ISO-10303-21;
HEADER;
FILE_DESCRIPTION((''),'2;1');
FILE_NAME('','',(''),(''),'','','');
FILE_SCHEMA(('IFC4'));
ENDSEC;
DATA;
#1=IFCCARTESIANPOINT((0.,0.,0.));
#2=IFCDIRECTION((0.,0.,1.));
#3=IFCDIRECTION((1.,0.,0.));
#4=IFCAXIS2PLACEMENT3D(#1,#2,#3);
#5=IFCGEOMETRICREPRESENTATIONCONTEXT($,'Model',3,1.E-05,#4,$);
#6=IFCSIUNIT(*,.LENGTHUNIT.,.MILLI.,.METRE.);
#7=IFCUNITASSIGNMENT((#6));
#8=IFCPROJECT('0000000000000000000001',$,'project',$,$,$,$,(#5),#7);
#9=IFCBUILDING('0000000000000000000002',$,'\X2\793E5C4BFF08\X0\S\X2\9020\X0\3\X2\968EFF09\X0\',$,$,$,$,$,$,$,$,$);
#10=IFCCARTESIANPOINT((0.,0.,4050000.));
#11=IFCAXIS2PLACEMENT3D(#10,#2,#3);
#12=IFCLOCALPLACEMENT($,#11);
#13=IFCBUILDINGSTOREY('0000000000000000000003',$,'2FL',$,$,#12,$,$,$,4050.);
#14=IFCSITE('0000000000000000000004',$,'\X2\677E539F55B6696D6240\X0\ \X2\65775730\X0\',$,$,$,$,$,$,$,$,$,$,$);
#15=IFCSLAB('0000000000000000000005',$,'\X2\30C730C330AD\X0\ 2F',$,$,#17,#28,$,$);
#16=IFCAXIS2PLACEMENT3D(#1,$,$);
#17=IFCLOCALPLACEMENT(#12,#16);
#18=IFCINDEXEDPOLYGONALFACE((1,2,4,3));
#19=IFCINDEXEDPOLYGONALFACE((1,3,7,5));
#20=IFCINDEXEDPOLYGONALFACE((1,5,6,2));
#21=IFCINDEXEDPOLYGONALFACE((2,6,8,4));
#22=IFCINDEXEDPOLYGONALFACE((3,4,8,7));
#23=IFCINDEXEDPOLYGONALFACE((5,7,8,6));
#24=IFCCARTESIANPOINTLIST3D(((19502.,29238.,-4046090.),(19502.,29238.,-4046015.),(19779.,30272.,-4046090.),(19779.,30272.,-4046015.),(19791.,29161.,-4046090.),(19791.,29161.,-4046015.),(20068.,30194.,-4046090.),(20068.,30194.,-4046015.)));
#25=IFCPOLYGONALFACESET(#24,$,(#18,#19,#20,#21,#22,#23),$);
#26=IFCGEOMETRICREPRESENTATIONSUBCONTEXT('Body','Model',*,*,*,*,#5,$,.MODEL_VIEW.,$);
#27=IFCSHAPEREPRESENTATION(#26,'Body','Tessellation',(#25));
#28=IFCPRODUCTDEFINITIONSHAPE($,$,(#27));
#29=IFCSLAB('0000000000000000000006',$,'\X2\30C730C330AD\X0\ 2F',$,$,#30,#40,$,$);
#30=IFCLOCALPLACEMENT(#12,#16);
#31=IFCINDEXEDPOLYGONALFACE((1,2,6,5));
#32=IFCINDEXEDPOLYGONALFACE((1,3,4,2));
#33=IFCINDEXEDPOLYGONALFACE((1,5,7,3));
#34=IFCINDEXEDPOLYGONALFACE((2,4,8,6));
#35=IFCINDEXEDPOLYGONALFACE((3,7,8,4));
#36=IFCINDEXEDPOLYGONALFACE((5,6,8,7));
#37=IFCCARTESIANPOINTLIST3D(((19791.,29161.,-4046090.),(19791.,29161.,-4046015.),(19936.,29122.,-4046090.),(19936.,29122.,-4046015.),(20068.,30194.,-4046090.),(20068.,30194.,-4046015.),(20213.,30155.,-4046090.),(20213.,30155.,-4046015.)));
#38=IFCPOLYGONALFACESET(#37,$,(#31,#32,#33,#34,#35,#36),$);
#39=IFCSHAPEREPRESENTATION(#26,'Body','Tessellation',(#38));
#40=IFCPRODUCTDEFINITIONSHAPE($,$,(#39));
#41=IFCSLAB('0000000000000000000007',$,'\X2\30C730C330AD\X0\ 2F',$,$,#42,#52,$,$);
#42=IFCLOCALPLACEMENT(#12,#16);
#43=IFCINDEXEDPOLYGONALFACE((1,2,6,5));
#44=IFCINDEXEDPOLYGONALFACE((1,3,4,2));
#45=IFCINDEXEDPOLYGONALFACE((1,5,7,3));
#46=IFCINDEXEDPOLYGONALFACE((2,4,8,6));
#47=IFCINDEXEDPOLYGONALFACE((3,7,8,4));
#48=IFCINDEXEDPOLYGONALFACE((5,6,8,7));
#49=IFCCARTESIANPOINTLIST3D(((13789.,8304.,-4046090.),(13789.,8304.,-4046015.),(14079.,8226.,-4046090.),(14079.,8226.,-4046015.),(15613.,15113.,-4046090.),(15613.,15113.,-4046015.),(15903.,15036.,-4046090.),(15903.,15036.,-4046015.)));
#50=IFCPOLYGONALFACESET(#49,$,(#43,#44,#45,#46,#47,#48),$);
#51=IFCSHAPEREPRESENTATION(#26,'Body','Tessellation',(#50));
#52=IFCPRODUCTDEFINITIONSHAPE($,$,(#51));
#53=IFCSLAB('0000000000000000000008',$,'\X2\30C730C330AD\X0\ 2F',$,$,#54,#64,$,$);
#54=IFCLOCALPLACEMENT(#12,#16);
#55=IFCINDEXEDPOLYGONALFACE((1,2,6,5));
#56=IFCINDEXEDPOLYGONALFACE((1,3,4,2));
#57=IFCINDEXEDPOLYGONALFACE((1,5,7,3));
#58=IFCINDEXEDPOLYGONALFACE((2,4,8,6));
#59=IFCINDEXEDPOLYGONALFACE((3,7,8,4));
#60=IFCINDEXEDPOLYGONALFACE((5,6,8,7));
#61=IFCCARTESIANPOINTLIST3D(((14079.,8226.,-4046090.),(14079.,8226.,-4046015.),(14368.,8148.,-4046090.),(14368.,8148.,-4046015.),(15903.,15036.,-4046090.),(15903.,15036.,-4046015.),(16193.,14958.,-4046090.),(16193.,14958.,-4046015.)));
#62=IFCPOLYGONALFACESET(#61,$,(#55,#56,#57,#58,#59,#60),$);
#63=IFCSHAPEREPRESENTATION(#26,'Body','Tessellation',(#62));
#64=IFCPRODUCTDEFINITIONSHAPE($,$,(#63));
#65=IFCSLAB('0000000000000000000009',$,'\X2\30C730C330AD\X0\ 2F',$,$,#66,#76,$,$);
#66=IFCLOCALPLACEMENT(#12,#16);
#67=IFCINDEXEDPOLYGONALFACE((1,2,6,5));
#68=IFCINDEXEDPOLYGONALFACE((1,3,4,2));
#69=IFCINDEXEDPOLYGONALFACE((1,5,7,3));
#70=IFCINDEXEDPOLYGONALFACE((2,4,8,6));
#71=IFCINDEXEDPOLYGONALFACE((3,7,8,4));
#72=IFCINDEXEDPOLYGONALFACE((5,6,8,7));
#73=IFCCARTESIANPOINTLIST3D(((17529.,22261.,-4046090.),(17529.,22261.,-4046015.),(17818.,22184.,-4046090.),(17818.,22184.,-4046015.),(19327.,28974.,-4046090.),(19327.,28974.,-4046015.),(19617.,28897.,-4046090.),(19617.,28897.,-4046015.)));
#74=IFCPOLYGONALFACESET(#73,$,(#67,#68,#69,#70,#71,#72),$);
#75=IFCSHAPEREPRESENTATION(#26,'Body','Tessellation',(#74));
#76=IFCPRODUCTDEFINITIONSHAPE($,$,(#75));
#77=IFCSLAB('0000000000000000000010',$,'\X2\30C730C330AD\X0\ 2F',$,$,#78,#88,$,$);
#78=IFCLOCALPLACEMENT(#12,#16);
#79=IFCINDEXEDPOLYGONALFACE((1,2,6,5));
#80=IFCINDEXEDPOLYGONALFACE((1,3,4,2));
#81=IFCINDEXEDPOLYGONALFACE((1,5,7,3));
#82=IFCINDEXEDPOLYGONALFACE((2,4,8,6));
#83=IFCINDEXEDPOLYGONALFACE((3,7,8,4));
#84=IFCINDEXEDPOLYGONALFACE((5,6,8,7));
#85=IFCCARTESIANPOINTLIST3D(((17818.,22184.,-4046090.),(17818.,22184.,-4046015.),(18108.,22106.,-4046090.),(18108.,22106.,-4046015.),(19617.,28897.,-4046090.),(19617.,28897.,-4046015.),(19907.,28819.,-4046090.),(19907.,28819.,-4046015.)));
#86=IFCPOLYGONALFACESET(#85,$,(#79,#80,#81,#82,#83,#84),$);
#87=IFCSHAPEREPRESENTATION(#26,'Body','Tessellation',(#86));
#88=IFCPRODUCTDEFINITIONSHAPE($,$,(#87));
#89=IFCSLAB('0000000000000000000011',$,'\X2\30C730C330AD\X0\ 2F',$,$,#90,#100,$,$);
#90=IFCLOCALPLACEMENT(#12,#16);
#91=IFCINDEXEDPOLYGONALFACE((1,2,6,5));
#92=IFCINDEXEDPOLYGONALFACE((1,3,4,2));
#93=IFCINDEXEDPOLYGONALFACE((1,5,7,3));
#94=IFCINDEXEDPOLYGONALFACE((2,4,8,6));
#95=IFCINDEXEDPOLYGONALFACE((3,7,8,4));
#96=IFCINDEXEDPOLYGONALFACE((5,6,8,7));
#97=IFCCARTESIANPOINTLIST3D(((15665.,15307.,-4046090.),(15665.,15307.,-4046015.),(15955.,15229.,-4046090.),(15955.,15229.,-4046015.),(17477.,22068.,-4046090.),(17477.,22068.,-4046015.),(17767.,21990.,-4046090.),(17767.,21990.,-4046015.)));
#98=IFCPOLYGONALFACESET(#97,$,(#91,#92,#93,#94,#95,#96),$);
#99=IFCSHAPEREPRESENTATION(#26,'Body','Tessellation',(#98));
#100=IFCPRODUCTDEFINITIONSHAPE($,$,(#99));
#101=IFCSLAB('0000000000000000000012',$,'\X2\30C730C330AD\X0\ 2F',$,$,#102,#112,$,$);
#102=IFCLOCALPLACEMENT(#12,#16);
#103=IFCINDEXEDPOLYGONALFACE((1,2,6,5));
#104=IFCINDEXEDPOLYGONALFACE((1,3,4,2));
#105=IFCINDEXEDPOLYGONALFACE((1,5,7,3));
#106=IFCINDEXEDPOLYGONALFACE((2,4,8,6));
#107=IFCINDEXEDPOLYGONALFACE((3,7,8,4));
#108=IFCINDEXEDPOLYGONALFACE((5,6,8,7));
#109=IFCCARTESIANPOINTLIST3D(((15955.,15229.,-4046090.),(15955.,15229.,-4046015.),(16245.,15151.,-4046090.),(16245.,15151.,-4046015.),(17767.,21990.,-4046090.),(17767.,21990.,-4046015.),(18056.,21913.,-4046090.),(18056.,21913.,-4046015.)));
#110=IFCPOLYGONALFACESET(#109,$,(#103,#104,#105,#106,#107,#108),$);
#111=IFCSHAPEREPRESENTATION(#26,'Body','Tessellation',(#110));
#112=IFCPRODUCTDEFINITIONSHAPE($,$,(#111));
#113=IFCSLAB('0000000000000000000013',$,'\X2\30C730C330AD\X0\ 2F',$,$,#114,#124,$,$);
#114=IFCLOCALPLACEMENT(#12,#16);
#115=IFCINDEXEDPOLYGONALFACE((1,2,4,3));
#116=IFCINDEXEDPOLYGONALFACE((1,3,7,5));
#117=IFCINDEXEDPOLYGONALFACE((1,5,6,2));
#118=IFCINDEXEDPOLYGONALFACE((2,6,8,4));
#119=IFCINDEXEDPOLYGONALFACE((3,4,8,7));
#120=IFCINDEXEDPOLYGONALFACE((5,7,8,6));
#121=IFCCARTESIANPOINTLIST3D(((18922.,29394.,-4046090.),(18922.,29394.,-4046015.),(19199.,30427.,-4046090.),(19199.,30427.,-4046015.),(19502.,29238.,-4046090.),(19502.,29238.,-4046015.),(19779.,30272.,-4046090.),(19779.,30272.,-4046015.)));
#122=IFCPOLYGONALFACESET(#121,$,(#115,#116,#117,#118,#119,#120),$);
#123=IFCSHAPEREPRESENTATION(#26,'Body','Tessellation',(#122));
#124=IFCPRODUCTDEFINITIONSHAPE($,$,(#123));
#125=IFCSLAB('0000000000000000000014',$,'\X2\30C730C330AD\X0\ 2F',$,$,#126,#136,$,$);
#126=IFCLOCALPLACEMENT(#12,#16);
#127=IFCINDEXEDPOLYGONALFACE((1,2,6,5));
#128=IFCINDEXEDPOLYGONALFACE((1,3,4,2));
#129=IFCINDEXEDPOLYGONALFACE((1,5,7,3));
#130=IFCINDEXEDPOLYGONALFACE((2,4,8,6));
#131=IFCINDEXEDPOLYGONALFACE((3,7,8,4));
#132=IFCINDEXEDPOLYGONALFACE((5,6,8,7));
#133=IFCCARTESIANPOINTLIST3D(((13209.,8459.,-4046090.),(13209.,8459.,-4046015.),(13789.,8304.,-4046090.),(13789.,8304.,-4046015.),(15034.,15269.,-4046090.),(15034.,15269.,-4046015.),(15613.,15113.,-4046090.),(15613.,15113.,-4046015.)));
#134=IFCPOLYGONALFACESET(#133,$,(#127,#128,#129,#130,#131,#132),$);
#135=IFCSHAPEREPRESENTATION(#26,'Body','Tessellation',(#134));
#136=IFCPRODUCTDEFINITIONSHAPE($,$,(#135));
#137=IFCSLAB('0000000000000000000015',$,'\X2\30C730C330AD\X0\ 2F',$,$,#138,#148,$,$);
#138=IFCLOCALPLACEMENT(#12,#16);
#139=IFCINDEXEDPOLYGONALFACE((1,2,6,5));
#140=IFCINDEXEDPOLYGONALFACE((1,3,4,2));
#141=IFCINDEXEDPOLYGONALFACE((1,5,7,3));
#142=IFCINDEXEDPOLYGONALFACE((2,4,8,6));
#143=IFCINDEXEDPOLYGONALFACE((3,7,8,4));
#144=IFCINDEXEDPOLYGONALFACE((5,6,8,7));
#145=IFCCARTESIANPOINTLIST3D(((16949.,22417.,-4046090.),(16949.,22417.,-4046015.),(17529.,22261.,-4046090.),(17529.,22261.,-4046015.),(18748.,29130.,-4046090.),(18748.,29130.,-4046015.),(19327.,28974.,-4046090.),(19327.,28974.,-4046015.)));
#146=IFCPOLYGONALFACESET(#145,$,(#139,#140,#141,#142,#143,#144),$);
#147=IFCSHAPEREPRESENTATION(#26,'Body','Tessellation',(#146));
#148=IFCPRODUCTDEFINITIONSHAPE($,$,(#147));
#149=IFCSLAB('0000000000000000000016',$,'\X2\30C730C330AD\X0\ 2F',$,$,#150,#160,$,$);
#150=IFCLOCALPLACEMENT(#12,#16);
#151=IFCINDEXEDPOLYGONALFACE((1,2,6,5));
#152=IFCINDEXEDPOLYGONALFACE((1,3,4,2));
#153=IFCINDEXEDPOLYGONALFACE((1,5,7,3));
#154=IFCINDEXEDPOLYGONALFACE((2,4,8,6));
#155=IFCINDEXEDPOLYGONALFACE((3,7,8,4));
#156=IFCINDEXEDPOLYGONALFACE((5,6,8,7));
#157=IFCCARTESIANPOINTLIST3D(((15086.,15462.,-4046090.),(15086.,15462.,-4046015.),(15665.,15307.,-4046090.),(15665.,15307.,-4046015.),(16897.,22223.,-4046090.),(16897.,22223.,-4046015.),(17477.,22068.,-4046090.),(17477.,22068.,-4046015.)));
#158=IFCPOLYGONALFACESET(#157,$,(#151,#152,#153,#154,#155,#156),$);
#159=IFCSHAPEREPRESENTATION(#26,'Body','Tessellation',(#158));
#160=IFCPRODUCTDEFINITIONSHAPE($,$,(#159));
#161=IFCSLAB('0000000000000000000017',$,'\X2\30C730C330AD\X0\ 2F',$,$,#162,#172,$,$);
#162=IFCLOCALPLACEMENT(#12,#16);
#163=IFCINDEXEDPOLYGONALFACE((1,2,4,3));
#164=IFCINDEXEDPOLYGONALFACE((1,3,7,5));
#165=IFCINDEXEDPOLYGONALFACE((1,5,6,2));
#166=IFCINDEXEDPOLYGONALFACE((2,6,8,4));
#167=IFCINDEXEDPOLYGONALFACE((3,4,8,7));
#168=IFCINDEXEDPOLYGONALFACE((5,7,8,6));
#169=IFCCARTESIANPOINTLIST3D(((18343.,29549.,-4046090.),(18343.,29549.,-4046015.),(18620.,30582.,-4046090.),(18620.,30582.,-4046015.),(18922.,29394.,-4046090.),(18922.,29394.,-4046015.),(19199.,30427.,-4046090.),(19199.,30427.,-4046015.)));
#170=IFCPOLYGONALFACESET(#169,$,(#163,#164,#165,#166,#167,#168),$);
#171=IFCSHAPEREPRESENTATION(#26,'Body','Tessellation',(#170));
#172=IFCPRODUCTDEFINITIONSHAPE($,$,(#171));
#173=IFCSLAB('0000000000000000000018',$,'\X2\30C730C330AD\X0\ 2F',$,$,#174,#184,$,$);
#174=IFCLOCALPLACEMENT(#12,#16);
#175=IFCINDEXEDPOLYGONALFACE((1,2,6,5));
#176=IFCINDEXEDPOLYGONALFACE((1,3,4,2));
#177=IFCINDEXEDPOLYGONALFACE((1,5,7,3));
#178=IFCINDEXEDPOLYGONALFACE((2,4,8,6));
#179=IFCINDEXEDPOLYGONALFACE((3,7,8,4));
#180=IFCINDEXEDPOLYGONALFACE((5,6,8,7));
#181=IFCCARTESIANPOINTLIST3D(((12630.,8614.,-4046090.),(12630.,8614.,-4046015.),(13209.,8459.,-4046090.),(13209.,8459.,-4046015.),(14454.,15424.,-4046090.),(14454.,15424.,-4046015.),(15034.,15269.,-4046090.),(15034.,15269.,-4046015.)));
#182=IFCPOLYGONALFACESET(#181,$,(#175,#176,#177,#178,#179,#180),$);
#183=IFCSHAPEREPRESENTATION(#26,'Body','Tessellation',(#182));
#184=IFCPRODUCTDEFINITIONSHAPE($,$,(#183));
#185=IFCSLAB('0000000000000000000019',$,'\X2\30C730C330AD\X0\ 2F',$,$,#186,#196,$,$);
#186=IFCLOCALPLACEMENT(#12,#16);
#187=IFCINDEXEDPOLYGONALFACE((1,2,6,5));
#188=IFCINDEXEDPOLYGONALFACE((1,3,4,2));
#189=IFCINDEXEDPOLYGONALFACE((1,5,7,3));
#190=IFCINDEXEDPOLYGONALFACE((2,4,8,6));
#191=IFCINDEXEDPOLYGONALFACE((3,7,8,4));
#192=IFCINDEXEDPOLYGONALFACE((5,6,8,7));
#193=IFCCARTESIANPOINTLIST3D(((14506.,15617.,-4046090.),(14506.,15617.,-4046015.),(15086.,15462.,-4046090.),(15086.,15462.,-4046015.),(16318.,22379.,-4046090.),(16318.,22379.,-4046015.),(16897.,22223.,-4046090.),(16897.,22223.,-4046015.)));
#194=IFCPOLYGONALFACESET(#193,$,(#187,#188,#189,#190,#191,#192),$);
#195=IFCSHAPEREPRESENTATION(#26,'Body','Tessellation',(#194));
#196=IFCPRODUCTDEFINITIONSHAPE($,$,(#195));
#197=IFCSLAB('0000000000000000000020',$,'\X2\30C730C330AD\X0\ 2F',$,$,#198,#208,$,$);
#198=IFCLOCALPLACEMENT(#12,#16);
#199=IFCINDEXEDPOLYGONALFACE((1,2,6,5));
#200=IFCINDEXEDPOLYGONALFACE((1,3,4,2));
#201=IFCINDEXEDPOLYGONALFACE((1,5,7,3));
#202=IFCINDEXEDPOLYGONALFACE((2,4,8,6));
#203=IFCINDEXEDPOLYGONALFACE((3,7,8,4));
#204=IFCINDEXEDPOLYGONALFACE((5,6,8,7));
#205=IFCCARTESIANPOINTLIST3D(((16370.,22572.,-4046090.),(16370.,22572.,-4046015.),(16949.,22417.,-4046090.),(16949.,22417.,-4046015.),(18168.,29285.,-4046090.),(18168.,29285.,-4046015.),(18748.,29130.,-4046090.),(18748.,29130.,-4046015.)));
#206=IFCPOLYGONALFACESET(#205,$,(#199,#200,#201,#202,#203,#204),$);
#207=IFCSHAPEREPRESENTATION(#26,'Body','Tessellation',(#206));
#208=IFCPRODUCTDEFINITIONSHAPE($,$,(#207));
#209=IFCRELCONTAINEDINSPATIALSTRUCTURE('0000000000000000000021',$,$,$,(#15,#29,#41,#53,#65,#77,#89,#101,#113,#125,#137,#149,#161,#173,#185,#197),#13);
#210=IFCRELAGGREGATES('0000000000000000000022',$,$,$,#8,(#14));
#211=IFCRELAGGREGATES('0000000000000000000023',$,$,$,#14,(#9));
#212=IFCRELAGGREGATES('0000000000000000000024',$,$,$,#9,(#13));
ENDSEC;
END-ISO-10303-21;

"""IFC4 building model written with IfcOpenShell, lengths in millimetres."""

from ifc_helpers import new_model, si_unit, frame, origin, origin_with_axes, place, context, subcontext, project, spatial, polyline, outline, extrude, element, save


model = new_model("IFC4")

# Units and contexts
model_context = context("Model", 3, precision=1e-05, world=origin_with_axes())
body_context = subcontext(model_context, "Body", "Model", "MODEL_VIEW")
ifc_project = project(units=[si_unit("LENGTHUNIT", "METRE", prefix="MILLI")], contexts=[model_context])

# Site, building, storey
site = spatial("IfcSite", under=ifc_project, Name="松原営業所 敷地")
building = spatial("IfcBuilding", under=site, Name="社屋（S造3階）")
storey_placement = place(None, frame((0.0, 0.0, 4050000.0), z_axis=(0.0, 0.0, 1.0), x_axis=(1.0, 0.0, 0.0)))
storey = spatial("IfcBuildingStorey", under=building, at=storey_placement, Name="2FL", Elevation=4050.0)

# Slabs
slab_1_placement = place(storey_placement, frame((0.0, 0.0, -4046090.0), z_axis=(0.0, 0.0, 1.0), x_axis=(1.0, 0.0, 0.0)))
element("IfcSlab", 1, at=slab_1_placement, inside=storey, Name="デッキ 2F", context=body_context, shape_type="SweptSolid", body=[
    extrude(outline(polyline([(19791.0, 29161.0), (20068.0, 30194.0), (19779.0, 30272.0), (19502.0, 29238.0), (19791.0, 29161.0)])), origin(), (0.0, 0.0, 1.0), 75.0),
])
slab_2_placement = place(storey_placement, frame((0.0, 0.0, -4046090.0), z_axis=(0.0, 0.0, 1.0), x_axis=(1.0, 0.0, 0.0)))
element("IfcSlab", 2, at=slab_2_placement, inside=storey, Name="デッキ 2F", context=body_context, shape_type="SweptSolid", body=[
    extrude(outline(polyline([(19791.0, 29161.0), (20068.0, 30194.0), (20213.0, 30155.0), (19936.0, 29122.0), (19791.0, 29161.0)])), origin(), (0.0, 0.0, 1.0), 75.0),
])
slab_3_placement = place(storey_placement, frame((0.0, 0.0, -4046090.0), z_axis=(0.0, 0.0, 1.0), x_axis=(1.0, 0.0, 0.0)))
element("IfcSlab", 3, at=slab_3_placement, inside=storey, Name="デッキ 2F", context=body_context, shape_type="SweptSolid", body=[
    extrude(outline(polyline([(14079.0, 8226.0), (15903.0, 15036.0), (15613.0, 15113.0), (13789.0, 8304.0), (14079.0, 8226.0)])), origin(), (0.0, 0.0, 1.0), 75.0),
])
slab_4_placement = place(storey_placement, frame((0.0, 0.0, -4046090.0), z_axis=(0.0, 0.0, 1.0), x_axis=(1.0, 0.0, 0.0)))
element("IfcSlab", 4, at=slab_4_placement, inside=storey, Name="デッキ 2F", context=body_context, shape_type="SweptSolid", body=[
    extrude(outline(polyline([(14079.0, 8226.0), (15903.0, 15036.0), (16193.0, 14958.0), (14368.0, 8148.0), (14079.0, 8226.0)])), origin(), (0.0, 0.0, 1.0), 75.0),
])
slab_5_placement = place(storey_placement, frame((0.0, 0.0, -4046090.0), z_axis=(0.0, 0.0, 1.0), x_axis=(1.0, 0.0, 0.0)))
element("IfcSlab", 5, at=slab_5_placement, inside=storey, Name="デッキ 2F", context=body_context, shape_type="SweptSolid", body=[
    extrude(outline(polyline([(17818.0, 22184.0), (19617.0, 28897.0), (19327.0, 28974.0), (17529.0, 22261.0), (17818.0, 22184.0)])), origin(), (0.0, 0.0, 1.0), 75.0),
])
slab_6_placement = place(storey_placement, frame((0.0, 0.0, -4046090.0), z_axis=(0.0, 0.0, 1.0), x_axis=(1.0, 0.0, 0.0)))
element("IfcSlab", 6, at=slab_6_placement, inside=storey, Name="デッキ 2F", context=body_context, shape_type="SweptSolid", body=[
    extrude(outline(polyline([(17818.0, 22184.0), (19617.0, 28897.0), (19907.0, 28819.0), (18108.0, 22106.0), (17818.0, 22184.0)])), origin(), (0.0, 0.0, 1.0), 75.0),
])
slab_7_placement = place(storey_placement, frame((0.0, 0.0, -4046090.0), z_axis=(0.0, 0.0, 1.0), x_axis=(1.0, 0.0, 0.0)))
element("IfcSlab", 7, at=slab_7_placement, inside=storey, Name="デッキ 2F", context=body_context, shape_type="SweptSolid", body=[
    extrude(outline(polyline([(15955.0, 15229.0), (17767.0, 21990.0), (17477.0, 22068.0), (15665.0, 15307.0), (15955.0, 15229.0)])), origin(), (0.0, 0.0, 1.0), 75.0),
])
slab_8_placement = place(storey_placement, frame((0.0, 0.0, -4046090.0), z_axis=(0.0, 0.0, 1.0), x_axis=(1.0, 0.0, 0.0)))
element("IfcSlab", 8, at=slab_8_placement, inside=storey, Name="デッキ 2F", context=body_context, shape_type="SweptSolid", body=[
    extrude(outline(polyline([(15955.0, 15229.0), (17767.0, 21990.0), (18056.0, 21913.0), (16245.0, 15151.0), (15955.0, 15229.0)])), origin(), (0.0, 0.0, 1.0), 75.0),
])
slab_9_placement = place(storey_placement, frame((0.0, 0.0, -4046090.0), z_axis=(0.0, 0.0, 1.0), x_axis=(1.0, 0.0, 0.0)))
element("IfcSlab", 9, at=slab_9_placement, inside=storey, Name="デッキ 2F", context=body_context, shape_type="SweptSolid", body=[
    extrude(outline(polyline([(19502.0, 29238.0), (19779.0, 30272.0), (19199.0, 30427.0), (18922.0, 29394.0), (19502.0, 29238.0)])), origin(), (0.0, 0.0, 1.0), 75.0),
])
slab_10_placement = place(storey_placement, frame((0.0, 0.0, -4046090.0), z_axis=(0.0, 0.0, 1.0), x_axis=(1.0, 0.0, 0.0)))
element("IfcSlab", 10, at=slab_10_placement, inside=storey, Name="デッキ 2F", context=body_context, shape_type="SweptSolid", body=[
    extrude(outline(polyline([(13789.0, 8304.0), (15613.0, 15113.0), (15034.0, 15269.0), (13209.0, 8459.0), (13789.0, 8304.0)])), origin(), (0.0, 0.0, 1.0), 75.0),
])
slab_11_placement = place(storey_placement, frame((0.0, 0.0, -4046090.0), z_axis=(0.0, 0.0, 1.0), x_axis=(1.0, 0.0, 0.0)))
element("IfcSlab", 11, at=slab_11_placement, inside=storey, Name="デッキ 2F", context=body_context, shape_type="SweptSolid", body=[
    extrude(outline(polyline([(17529.0, 22261.0), (19327.0, 28974.0), (18748.0, 29130.0), (16949.0, 22417.0), (17529.0, 22261.0)])), origin(), (0.0, 0.0, 1.0), 75.0),
])
slab_12_placement = place(storey_placement, frame((0.0, 0.0, -4046090.0), z_axis=(0.0, 0.0, 1.0), x_axis=(1.0, 0.0, 0.0)))
element("IfcSlab", 12, at=slab_12_placement, inside=storey, Name="デッキ 2F", context=body_context, shape_type="SweptSolid", body=[
    extrude(outline(polyline([(15665.0, 15307.0), (17477.0, 22068.0), (16897.0, 22223.0), (15086.0, 15462.0), (15665.0, 15307.0)])), origin(), (0.0, 0.0, 1.0), 75.0),
])
slab_13_placement = place(storey_placement, frame((0.0, 0.0, -4046090.0), z_axis=(0.0, 0.0, 1.0), x_axis=(1.0, 0.0, 0.0)))
element("IfcSlab", 13, at=slab_13_placement, inside=storey, Name="デッキ 2F", context=body_context, shape_type="SweptSolid", body=[
    extrude(outline(polyline([(18922.0, 29394.0), (19199.0, 30427.0), (18620.0, 30582.0), (18343.0, 29549.0), (18922.0, 29394.0)])), origin(), (0.0, 0.0, 1.0), 75.0),
])
slab_14_placement = place(storey_placement, frame((0.0, 0.0, -4046090.0), z_axis=(0.0, 0.0, 1.0), x_axis=(1.0, 0.0, 0.0)))
element("IfcSlab", 14, at=slab_14_placement, inside=storey, Name="デッキ 2F", context=body_context, shape_type="SweptSolid", body=[
    extrude(outline(polyline([(13209.0, 8459.0), (15034.0, 15269.0), (14454.0, 15424.0), (12630.0, 8614.0), (13209.0, 8459.0)])), origin(), (0.0, 0.0, 1.0), 75.0),
])
slab_15_placement = place(storey_placement, frame((0.0, 0.0, -4046090.0), z_axis=(0.0, 0.0, 1.0), x_axis=(1.0, 0.0, 0.0)))
element("IfcSlab", 15, at=slab_15_placement, inside=storey, Name="デッキ 2F", context=body_context, shape_type="SweptSolid", body=[
    extrude(outline(polyline([(15086.0, 15462.0), (16897.0, 22223.0), (16318.0, 22379.0), (14506.0, 15617.0), (15086.0, 15462.0)])), origin(), (0.0, 0.0, 1.0), 75.0),
])
slab_16_placement = place(storey_placement, frame((0.0, 0.0, -4046090.0), z_axis=(0.0, 0.0, 1.0), x_axis=(1.0, 0.0, 0.0)))
element("IfcSlab", 16, at=slab_16_placement, inside=storey, Name="デッキ 2F", context=body_context, shape_type="SweptSolid", body=[
    extrude(outline(polyline([(16949.0, 22417.0), (18748.0, 29130.0), (18168.0, 29285.0), (16370.0, 22572.0), (16949.0, 22417.0)])), origin(), (0.0, 0.0, 1.0), 75.0),
])

save(model, "model.ifc")
